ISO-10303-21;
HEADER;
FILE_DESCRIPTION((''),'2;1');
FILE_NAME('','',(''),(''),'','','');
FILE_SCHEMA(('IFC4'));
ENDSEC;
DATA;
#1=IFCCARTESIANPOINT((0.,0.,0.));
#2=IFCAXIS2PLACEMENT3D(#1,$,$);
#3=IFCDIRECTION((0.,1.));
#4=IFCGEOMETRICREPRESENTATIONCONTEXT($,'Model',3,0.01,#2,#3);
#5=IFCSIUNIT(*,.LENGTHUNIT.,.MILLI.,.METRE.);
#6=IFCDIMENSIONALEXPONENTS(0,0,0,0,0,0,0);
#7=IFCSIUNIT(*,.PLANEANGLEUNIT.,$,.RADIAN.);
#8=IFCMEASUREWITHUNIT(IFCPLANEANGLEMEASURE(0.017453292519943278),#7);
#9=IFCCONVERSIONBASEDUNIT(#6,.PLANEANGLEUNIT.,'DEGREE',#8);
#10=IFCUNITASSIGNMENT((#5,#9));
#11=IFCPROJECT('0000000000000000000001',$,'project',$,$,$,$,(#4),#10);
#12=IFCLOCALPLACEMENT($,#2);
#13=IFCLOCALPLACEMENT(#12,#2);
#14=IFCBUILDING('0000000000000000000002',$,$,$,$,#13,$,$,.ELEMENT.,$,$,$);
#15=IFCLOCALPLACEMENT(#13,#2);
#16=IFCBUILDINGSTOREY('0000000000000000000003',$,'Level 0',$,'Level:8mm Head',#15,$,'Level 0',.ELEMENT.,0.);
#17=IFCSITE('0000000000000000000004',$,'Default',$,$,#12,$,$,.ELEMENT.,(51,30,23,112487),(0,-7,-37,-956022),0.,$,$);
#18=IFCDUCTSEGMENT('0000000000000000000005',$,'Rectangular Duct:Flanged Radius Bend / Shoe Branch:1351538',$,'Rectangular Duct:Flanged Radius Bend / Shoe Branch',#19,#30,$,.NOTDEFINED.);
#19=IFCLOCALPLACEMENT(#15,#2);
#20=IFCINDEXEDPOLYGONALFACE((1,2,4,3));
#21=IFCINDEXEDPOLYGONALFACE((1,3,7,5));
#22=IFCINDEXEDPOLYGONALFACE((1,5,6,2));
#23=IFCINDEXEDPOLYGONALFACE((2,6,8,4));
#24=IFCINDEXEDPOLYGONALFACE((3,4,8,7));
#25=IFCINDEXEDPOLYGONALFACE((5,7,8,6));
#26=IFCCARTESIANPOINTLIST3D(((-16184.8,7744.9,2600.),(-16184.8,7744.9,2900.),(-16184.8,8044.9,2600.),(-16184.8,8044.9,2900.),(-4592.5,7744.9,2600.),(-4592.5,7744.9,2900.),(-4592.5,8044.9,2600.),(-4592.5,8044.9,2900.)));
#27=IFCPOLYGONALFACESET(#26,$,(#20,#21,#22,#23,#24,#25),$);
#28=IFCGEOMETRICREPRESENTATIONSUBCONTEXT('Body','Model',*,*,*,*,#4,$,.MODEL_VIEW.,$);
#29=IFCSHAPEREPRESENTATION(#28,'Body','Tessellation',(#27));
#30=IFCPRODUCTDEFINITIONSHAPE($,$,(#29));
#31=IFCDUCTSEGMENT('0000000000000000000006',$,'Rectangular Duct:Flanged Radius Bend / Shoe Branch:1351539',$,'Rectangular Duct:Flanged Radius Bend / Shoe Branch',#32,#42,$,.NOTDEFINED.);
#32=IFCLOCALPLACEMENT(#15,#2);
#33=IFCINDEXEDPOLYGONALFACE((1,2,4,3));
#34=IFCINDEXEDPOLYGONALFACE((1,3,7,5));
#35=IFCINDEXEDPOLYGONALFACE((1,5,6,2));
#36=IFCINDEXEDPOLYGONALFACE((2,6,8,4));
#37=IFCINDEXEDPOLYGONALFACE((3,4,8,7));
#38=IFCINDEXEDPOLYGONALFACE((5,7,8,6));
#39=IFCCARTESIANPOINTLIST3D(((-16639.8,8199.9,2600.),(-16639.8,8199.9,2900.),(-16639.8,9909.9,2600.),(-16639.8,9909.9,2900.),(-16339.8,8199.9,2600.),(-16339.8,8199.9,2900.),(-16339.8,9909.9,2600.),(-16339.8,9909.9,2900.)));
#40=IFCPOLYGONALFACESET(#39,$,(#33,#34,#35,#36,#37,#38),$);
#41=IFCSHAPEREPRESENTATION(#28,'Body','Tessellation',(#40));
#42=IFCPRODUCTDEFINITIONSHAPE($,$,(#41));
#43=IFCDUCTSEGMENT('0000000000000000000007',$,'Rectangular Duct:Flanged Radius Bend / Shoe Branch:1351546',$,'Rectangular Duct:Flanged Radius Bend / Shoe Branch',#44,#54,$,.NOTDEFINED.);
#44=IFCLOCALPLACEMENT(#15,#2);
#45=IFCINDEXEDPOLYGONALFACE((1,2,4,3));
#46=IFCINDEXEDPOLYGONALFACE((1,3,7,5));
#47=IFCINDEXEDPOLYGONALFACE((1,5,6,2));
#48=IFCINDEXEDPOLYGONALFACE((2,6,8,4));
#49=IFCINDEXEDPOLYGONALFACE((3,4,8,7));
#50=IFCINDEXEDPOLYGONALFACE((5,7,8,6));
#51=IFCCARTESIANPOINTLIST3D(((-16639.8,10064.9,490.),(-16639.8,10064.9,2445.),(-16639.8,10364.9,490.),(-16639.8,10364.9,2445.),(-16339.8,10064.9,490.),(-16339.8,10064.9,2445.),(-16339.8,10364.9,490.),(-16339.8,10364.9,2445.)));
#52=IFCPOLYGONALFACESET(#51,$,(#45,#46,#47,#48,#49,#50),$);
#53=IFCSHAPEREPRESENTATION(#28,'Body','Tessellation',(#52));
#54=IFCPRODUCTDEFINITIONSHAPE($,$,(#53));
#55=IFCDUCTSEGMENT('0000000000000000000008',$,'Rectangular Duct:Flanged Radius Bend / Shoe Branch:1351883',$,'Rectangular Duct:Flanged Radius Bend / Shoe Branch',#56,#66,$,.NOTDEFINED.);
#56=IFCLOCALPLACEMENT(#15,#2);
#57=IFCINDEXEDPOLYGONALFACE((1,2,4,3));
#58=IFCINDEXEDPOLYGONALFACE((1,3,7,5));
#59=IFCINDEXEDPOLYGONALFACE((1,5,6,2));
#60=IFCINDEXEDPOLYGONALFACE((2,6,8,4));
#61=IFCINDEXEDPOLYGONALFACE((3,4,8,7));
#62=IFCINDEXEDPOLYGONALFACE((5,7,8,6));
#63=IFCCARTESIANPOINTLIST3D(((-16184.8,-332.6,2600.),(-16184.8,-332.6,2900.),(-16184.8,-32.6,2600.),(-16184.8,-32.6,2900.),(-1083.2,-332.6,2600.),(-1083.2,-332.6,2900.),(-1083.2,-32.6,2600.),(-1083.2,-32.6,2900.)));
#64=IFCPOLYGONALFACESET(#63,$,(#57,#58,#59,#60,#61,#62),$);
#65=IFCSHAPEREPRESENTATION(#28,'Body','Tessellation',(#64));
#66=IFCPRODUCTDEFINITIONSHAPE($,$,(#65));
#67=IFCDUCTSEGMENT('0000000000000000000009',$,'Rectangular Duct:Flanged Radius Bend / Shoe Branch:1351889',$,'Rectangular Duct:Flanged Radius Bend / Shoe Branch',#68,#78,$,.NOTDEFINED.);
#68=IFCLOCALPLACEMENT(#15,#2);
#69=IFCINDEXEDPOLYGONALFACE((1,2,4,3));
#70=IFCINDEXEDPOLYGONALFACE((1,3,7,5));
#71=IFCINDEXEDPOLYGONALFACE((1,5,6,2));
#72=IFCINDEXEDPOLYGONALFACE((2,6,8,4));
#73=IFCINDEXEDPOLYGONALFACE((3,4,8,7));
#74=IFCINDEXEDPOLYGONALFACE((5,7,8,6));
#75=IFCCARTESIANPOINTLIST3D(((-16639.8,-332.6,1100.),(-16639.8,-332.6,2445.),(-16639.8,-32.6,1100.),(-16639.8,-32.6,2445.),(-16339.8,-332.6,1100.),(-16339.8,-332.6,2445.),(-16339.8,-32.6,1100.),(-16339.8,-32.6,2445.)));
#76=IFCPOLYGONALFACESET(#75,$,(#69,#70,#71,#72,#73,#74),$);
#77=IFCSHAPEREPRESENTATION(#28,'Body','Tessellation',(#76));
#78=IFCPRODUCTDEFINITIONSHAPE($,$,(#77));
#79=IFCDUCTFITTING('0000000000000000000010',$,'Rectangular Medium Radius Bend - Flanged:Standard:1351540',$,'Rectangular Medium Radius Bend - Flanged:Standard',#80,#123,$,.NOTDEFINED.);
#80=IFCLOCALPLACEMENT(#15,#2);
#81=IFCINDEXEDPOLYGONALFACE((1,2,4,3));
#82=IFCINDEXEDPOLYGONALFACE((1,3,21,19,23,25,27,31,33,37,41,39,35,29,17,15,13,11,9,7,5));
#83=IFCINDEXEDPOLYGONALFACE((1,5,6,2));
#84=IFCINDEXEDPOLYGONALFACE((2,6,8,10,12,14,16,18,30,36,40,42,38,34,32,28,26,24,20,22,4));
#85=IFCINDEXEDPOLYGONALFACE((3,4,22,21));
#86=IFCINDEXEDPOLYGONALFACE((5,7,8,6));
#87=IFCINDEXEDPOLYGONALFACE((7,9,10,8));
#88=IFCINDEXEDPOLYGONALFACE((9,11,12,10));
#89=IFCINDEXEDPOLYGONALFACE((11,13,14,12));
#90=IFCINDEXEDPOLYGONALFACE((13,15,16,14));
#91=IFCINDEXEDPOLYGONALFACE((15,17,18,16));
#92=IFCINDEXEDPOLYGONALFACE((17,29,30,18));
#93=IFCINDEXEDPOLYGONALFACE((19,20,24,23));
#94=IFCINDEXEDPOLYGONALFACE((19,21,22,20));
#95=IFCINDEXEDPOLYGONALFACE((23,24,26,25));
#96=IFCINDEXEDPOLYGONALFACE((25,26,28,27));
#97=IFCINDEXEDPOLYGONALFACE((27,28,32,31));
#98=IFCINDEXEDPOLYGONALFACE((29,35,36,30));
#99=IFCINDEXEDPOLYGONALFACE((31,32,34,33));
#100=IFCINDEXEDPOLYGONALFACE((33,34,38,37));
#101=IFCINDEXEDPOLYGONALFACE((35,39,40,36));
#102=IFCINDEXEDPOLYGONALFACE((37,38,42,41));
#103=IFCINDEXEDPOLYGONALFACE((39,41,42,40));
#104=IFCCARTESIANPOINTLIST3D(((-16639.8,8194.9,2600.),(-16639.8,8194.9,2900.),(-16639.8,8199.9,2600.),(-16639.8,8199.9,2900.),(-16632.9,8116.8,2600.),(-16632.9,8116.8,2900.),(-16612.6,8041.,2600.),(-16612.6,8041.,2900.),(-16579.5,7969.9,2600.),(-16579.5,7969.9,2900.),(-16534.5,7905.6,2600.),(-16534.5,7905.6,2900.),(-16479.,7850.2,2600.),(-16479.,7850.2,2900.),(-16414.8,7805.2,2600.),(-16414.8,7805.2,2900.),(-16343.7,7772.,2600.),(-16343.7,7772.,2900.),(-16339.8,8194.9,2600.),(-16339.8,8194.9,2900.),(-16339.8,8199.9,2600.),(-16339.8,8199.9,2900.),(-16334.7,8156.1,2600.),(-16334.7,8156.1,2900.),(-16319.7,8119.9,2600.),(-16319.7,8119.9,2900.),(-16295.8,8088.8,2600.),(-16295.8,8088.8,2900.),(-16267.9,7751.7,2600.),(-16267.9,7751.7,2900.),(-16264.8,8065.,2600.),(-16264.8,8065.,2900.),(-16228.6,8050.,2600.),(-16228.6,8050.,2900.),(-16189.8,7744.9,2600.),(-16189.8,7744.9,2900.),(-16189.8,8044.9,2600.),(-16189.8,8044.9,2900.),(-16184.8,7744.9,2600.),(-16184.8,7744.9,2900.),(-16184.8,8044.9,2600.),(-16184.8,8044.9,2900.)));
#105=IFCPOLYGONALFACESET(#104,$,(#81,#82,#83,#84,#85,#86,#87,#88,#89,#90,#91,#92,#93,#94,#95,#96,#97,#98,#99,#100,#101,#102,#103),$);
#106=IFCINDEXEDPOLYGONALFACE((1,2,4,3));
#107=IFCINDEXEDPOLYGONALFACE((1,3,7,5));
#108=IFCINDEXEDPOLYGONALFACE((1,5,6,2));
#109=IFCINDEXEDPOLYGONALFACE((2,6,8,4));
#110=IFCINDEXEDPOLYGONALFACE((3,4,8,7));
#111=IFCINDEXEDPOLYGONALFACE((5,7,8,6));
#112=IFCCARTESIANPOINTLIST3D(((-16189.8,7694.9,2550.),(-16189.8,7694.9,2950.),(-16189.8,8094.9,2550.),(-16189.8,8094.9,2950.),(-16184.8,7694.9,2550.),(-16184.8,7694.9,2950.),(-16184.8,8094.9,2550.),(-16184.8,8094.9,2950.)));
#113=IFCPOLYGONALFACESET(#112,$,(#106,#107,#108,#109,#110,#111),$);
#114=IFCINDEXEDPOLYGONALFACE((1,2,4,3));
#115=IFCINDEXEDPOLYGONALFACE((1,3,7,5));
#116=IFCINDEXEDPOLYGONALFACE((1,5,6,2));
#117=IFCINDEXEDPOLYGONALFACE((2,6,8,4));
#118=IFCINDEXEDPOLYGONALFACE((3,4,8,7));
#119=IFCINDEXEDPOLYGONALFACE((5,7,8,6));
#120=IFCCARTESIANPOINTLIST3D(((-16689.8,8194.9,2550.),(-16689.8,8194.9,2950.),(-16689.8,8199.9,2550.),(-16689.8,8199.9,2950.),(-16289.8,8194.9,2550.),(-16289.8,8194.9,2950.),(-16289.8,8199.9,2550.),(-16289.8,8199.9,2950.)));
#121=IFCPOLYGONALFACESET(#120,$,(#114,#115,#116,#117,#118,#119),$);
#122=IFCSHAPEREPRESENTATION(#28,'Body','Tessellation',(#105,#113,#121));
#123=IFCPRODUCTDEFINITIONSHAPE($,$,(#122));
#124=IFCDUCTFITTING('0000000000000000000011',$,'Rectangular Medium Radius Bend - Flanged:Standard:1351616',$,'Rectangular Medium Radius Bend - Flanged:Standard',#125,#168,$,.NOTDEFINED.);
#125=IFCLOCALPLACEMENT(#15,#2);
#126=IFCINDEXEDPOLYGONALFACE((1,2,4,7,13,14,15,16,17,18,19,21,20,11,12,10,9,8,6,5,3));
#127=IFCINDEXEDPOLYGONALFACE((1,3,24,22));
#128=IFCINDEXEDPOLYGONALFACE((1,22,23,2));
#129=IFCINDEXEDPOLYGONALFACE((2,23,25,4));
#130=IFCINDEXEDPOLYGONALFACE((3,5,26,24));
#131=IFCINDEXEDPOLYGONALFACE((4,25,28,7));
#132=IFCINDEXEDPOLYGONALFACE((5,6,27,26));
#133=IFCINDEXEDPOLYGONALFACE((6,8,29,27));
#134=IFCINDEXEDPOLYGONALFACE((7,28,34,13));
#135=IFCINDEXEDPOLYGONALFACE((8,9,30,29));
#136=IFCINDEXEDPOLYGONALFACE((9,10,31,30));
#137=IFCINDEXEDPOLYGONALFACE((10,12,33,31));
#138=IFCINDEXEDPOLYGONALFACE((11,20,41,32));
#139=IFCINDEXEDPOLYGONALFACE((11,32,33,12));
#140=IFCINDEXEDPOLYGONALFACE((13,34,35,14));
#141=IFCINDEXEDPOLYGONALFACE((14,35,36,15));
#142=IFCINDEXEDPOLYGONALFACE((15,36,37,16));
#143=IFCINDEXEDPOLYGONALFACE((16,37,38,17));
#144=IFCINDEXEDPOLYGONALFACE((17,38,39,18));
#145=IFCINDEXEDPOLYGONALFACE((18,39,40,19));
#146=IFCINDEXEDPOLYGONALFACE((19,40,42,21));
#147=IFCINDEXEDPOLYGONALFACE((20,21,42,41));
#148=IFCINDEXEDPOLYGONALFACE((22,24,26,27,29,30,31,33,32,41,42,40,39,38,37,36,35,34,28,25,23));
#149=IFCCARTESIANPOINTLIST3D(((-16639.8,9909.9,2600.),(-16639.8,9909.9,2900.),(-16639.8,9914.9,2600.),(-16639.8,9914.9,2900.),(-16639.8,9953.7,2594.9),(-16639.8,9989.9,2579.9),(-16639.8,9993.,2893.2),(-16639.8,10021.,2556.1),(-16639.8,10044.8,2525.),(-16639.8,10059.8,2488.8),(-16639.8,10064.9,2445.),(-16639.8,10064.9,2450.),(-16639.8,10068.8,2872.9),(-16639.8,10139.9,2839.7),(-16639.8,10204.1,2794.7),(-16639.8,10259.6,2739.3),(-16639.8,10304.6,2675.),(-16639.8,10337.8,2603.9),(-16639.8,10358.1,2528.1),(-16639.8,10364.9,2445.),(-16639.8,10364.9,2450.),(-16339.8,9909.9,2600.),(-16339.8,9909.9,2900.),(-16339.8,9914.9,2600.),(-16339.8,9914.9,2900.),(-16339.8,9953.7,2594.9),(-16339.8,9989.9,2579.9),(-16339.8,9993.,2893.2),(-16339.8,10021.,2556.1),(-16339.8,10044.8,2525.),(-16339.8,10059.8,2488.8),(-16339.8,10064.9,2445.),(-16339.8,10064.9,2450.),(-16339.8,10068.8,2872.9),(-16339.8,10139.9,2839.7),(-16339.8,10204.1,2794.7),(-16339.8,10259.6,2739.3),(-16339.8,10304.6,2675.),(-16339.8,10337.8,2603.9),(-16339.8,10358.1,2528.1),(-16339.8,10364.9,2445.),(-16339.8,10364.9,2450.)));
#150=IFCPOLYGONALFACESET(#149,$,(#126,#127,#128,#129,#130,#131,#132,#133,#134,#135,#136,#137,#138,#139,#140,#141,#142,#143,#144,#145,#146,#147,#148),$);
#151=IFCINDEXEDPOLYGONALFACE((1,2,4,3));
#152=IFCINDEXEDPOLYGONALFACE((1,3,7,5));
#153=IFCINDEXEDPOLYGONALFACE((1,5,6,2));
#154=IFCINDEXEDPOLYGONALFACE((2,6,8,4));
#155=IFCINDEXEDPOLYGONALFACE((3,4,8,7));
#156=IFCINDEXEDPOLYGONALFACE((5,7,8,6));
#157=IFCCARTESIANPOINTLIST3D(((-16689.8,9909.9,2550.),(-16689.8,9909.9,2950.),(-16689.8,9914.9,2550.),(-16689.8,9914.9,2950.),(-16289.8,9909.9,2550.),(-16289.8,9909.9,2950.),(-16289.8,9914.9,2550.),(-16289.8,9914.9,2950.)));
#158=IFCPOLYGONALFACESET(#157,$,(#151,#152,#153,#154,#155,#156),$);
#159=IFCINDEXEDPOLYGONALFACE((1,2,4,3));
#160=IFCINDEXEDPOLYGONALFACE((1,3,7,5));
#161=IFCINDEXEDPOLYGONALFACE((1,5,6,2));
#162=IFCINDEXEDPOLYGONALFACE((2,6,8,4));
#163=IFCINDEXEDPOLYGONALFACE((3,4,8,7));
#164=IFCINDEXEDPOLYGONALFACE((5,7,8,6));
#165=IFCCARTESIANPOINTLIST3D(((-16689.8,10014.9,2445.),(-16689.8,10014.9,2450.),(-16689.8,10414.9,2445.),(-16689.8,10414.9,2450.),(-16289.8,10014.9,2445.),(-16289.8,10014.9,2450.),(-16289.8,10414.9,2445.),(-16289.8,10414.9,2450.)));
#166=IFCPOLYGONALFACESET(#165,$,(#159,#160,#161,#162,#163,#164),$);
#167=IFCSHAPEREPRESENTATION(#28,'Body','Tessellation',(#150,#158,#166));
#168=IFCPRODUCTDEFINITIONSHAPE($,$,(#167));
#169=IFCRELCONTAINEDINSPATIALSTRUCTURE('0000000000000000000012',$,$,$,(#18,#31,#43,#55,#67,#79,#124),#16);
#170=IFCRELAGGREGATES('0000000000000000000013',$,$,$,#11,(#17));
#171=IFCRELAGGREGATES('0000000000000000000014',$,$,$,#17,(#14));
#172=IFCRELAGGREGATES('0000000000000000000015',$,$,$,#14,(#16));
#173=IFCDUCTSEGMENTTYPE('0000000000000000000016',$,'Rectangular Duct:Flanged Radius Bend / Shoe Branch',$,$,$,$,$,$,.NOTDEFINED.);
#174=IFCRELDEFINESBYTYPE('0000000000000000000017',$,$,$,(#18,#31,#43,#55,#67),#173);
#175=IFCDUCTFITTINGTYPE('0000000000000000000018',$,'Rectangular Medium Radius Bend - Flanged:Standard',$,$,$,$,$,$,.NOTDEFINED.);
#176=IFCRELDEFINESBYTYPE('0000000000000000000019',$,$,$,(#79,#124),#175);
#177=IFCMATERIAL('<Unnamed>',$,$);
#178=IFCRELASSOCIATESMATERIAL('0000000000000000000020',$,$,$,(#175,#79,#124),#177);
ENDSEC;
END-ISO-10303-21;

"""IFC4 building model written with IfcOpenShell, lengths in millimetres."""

from ifc_helpers import new_model, entity, si_unit, converted_unit, direction, frame, origin, place, context, subcontext, project, spatial, line, arc, indexed_curve, outline, extrude, source, transform, mapped, material, type_object, type_shapes, element, save


model = new_model("IFC4")

# Units and contexts
model_context = context("Model", 3, precision=0.01, world=origin(), true_north=direction((0.0, 1.0)))
body_context = subcontext(model_context, "Body", "Model", "MODEL_VIEW")
ifc_project = project(units=[si_unit("LENGTHUNIT", "METRE", prefix="MILLI"), converted_unit("PLANEANGLEUNIT", "DEGREE", entity("IfcPlaneAngleMeasure", 0.017453292519943278), si_unit("PLANEANGLEUNIT", "RADIAN"), dimensions=[0, 0, 0, 0, 0, 0, 0])], contexts=[model_context])

# Site, building, storey
site_placement = place(None, origin())
site = spatial("IfcSite", under=ifc_project, at=site_placement, Name="Default", CompositionType="ELEMENT", RefLatitude=(51, 30, 23, 112487), RefLongitude=(0, -7, -37, -956022), RefElevation=0.0)
building_placement = place(site_placement, origin())
building = spatial("IfcBuilding", under=site, at=building_placement, CompositionType="ELEMENT")
storey_placement = place(building_placement, origin())
storey = spatial("IfcBuildingStorey", under=building, at=storey_placement, Name="Level 0", ObjectType="Level:8mm Head", LongName="Level 0", CompositionType="ELEMENT", Elevation=0.0)

# Duct segments
duct_segment_type_1 = type_object("IfcDuctSegmentType", Name="Rectangular Duct:Flanged Radius Bend / Shoe Branch", PredefinedType="NOTDEFINED")
duct_segment_1_placement = place(storey_placement, origin())
element("IfcDuctSegment", 1, at=duct_segment_1_placement, inside=storey, type_object=duct_segment_type_1, Name="Rectangular Duct:Flanged Radius Bend / Shoe Branch:1351538", ObjectType="Rectangular Duct:Flanged Radius Bend / Shoe Branch", PredefinedType="NOTDEFINED", context=body_context, shape_type="SweptSolid", body=[
    extrude(outline(indexed_curve([(-5796.1, -150.0), (5796.1, -150.0), (5796.1, 150.0), (-5796.1, 150.0), (-5796.1, -150.0)], self_intersect=False)), frame((-10388.6, 7894.9, 2600.0), z_axis=(0.0, 0.0, 1.0), x_axis=(-1.0, 0.0, 0.0)), (0.0, 0.0, 1.0), 300.0),
])
duct_segment_2_placement = place(storey_placement, origin())
element("IfcDuctSegment", 2, at=duct_segment_2_placement, inside=storey, type_object=duct_segment_type_1, Name="Rectangular Duct:Flanged Radius Bend / Shoe Branch:1351539", ObjectType="Rectangular Duct:Flanged Radius Bend / Shoe Branch", PredefinedType="NOTDEFINED", context=body_context, shape_type="SweptSolid", body=[
    extrude(outline(indexed_curve([(-855.0, -150.0), (855.0, -150.0), (855.0, 150.0), (-855.0, 150.0), (-855.0, -150.0)], self_intersect=False)), frame((-16489.8, 9054.9, 2600.0), z_axis=(0.0, 0.0, 1.0), x_axis=(0.0, -1.0, 0.0)), (0.0, 0.0, 1.0), 300.0),
])
duct_segment_3_placement = place(storey_placement, origin())
element("IfcDuctSegment", 3, at=duct_segment_3_placement, inside=storey, type_object=duct_segment_type_1, Name="Rectangular Duct:Flanged Radius Bend / Shoe Branch:1351546", ObjectType="Rectangular Duct:Flanged Radius Bend / Shoe Branch", PredefinedType="NOTDEFINED", context=body_context, shape_type="SweptSolid", body=[
    extrude(outline(indexed_curve([(-150.0, -150.0), (150.0, -150.0), (150.0, 150.0), (-150.0, 150.0), (-150.0, -150.0)], self_intersect=False)), frame((-16489.8, 10214.9, 490.0), z_axis=(0.0, 0.0, 1.0), x_axis=(0.0, 1.0, 0.0)), (0.0, 0.0, 1.0), 1955.0),
])
duct_segment_4_placement = place(storey_placement, origin())
element("IfcDuctSegment", 4, at=duct_segment_4_placement, inside=storey, type_object=duct_segment_type_1, Name="Rectangular Duct:Flanged Radius Bend / Shoe Branch:1351883", ObjectType="Rectangular Duct:Flanged Radius Bend / Shoe Branch", PredefinedType="NOTDEFINED", context=body_context, shape_type="SweptSolid", body=[
    extrude(outline(indexed_curve([(-7550.8, -150.0), (7550.8, -150.0), (7550.8, 150.0), (-7550.8, 150.0), (-7550.8, -150.0)], self_intersect=False)), frame((-8634.0, -182.6, 2600.0)), (0.0, 0.0, 1.0), 300.0),
])
duct_segment_5_placement = place(storey_placement, origin())
element("IfcDuctSegment", 5, at=duct_segment_5_placement, inside=storey, type_object=duct_segment_type_1, Name="Rectangular Duct:Flanged Radius Bend / Shoe Branch:1351889", ObjectType="Rectangular Duct:Flanged Radius Bend / Shoe Branch", PredefinedType="NOTDEFINED", context=body_context, shape_type="SweptSolid", body=[
    extrude(outline(indexed_curve([(-150.0, -150.0), (150.0, -150.0), (150.0, 150.0), (-150.0, 150.0), (-150.0, -150.0)], self_intersect=False)), frame((-16489.8, -182.6, 1100.0), z_axis=(0.0, 0.0, 1.0), x_axis=(0.0, 1.0, 0.0)), (0.0, 0.0, 1.0), 1345.0),
])

# Duct fittings
ifc_material = material(Name="<Unnamed>")
duct_fitting_type = type_object("IfcDuctFittingType", Name="Rectangular Medium Radius Bend - Flanged:Standard", PredefinedType="NOTDEFINED", material=ifc_material)
shared_shape = source(origin(), body_context, "Body", "SweptSolid", [
    extrude(outline(indexed_curve([(-153.8, -301.2), (-148.7, -301.2), (169.4, -169.4), (301.3, 148.7), (301.3, 153.7), (1.3, 153.7), (1.3, 148.8), (-42.7, 42.7), (-148.7, -1.2), (-153.8, -1.2)], segments=[line(1, 2), arc(2, 3, 4), line(4, 5, 6, 7), arc(7, 8, 9), line(9, 10, 1)], self_intersect=False)), frame((-151.2, 151.2, -150.0)), (0.0, 0.0, 1.0), 300.0),
    extrude(outline(indexed_curve([(-2.5, -200.0), (2.5, -200.0), (2.5, 200.0), (-2.5, 200.0), (-2.5, -200.0)], self_intersect=False)), frame((0.0, 302.5, -200.0), z_axis=(0.0, 0.0, 1.0), x_axis=(0.0, 1.0, 0.0)), (0.0, 0.0, 1.0), 400.0),
    extrude(outline(indexed_curve([(-2.5, -200.0), (2.5, -200.0), (2.5, 200.0), (-2.5, 200.0), (-2.5, -200.0)], self_intersect=False)), frame((-302.5, 0.0, -200.0)), (0.0, 0.0, 1.0), 400.0),
])
type_shapes(duct_fitting_type, [shared_shape])
for number, where, z_axis, x_axis, name in (
    (6, (-16489.8, 7894.9, 2750.0), (0.0, 0.0, 1.0), (0.0, -1.0, 0.0), "Rectangular Medium Radius Bend - Flanged:Standard:1351540"),
    (7, (-16489.8, 10214.9, 2750.0), (1.0, 0.0, 0.0), (0.0, 0.0, 1.0), "Rectangular Medium Radius Bend - Flanged:Standard:1351616"),
):
    element("IfcDuctFitting", number, at=place(storey_placement, frame(where, z_axis=z_axis, x_axis=x_axis)), inside=storey, type_object=duct_fitting_type, material=ifc_material, Name=name, ObjectType="Rectangular Medium Radius Bend - Flanged:Standard", PredefinedType="NOTDEFINED", context=body_context, shape_type="MappedRepresentation", body=[
        mapped(shared_shape, transform((0.0, 0.0, 0.0), scale=1.0)),
    ])

save(model, "model.ifc")
